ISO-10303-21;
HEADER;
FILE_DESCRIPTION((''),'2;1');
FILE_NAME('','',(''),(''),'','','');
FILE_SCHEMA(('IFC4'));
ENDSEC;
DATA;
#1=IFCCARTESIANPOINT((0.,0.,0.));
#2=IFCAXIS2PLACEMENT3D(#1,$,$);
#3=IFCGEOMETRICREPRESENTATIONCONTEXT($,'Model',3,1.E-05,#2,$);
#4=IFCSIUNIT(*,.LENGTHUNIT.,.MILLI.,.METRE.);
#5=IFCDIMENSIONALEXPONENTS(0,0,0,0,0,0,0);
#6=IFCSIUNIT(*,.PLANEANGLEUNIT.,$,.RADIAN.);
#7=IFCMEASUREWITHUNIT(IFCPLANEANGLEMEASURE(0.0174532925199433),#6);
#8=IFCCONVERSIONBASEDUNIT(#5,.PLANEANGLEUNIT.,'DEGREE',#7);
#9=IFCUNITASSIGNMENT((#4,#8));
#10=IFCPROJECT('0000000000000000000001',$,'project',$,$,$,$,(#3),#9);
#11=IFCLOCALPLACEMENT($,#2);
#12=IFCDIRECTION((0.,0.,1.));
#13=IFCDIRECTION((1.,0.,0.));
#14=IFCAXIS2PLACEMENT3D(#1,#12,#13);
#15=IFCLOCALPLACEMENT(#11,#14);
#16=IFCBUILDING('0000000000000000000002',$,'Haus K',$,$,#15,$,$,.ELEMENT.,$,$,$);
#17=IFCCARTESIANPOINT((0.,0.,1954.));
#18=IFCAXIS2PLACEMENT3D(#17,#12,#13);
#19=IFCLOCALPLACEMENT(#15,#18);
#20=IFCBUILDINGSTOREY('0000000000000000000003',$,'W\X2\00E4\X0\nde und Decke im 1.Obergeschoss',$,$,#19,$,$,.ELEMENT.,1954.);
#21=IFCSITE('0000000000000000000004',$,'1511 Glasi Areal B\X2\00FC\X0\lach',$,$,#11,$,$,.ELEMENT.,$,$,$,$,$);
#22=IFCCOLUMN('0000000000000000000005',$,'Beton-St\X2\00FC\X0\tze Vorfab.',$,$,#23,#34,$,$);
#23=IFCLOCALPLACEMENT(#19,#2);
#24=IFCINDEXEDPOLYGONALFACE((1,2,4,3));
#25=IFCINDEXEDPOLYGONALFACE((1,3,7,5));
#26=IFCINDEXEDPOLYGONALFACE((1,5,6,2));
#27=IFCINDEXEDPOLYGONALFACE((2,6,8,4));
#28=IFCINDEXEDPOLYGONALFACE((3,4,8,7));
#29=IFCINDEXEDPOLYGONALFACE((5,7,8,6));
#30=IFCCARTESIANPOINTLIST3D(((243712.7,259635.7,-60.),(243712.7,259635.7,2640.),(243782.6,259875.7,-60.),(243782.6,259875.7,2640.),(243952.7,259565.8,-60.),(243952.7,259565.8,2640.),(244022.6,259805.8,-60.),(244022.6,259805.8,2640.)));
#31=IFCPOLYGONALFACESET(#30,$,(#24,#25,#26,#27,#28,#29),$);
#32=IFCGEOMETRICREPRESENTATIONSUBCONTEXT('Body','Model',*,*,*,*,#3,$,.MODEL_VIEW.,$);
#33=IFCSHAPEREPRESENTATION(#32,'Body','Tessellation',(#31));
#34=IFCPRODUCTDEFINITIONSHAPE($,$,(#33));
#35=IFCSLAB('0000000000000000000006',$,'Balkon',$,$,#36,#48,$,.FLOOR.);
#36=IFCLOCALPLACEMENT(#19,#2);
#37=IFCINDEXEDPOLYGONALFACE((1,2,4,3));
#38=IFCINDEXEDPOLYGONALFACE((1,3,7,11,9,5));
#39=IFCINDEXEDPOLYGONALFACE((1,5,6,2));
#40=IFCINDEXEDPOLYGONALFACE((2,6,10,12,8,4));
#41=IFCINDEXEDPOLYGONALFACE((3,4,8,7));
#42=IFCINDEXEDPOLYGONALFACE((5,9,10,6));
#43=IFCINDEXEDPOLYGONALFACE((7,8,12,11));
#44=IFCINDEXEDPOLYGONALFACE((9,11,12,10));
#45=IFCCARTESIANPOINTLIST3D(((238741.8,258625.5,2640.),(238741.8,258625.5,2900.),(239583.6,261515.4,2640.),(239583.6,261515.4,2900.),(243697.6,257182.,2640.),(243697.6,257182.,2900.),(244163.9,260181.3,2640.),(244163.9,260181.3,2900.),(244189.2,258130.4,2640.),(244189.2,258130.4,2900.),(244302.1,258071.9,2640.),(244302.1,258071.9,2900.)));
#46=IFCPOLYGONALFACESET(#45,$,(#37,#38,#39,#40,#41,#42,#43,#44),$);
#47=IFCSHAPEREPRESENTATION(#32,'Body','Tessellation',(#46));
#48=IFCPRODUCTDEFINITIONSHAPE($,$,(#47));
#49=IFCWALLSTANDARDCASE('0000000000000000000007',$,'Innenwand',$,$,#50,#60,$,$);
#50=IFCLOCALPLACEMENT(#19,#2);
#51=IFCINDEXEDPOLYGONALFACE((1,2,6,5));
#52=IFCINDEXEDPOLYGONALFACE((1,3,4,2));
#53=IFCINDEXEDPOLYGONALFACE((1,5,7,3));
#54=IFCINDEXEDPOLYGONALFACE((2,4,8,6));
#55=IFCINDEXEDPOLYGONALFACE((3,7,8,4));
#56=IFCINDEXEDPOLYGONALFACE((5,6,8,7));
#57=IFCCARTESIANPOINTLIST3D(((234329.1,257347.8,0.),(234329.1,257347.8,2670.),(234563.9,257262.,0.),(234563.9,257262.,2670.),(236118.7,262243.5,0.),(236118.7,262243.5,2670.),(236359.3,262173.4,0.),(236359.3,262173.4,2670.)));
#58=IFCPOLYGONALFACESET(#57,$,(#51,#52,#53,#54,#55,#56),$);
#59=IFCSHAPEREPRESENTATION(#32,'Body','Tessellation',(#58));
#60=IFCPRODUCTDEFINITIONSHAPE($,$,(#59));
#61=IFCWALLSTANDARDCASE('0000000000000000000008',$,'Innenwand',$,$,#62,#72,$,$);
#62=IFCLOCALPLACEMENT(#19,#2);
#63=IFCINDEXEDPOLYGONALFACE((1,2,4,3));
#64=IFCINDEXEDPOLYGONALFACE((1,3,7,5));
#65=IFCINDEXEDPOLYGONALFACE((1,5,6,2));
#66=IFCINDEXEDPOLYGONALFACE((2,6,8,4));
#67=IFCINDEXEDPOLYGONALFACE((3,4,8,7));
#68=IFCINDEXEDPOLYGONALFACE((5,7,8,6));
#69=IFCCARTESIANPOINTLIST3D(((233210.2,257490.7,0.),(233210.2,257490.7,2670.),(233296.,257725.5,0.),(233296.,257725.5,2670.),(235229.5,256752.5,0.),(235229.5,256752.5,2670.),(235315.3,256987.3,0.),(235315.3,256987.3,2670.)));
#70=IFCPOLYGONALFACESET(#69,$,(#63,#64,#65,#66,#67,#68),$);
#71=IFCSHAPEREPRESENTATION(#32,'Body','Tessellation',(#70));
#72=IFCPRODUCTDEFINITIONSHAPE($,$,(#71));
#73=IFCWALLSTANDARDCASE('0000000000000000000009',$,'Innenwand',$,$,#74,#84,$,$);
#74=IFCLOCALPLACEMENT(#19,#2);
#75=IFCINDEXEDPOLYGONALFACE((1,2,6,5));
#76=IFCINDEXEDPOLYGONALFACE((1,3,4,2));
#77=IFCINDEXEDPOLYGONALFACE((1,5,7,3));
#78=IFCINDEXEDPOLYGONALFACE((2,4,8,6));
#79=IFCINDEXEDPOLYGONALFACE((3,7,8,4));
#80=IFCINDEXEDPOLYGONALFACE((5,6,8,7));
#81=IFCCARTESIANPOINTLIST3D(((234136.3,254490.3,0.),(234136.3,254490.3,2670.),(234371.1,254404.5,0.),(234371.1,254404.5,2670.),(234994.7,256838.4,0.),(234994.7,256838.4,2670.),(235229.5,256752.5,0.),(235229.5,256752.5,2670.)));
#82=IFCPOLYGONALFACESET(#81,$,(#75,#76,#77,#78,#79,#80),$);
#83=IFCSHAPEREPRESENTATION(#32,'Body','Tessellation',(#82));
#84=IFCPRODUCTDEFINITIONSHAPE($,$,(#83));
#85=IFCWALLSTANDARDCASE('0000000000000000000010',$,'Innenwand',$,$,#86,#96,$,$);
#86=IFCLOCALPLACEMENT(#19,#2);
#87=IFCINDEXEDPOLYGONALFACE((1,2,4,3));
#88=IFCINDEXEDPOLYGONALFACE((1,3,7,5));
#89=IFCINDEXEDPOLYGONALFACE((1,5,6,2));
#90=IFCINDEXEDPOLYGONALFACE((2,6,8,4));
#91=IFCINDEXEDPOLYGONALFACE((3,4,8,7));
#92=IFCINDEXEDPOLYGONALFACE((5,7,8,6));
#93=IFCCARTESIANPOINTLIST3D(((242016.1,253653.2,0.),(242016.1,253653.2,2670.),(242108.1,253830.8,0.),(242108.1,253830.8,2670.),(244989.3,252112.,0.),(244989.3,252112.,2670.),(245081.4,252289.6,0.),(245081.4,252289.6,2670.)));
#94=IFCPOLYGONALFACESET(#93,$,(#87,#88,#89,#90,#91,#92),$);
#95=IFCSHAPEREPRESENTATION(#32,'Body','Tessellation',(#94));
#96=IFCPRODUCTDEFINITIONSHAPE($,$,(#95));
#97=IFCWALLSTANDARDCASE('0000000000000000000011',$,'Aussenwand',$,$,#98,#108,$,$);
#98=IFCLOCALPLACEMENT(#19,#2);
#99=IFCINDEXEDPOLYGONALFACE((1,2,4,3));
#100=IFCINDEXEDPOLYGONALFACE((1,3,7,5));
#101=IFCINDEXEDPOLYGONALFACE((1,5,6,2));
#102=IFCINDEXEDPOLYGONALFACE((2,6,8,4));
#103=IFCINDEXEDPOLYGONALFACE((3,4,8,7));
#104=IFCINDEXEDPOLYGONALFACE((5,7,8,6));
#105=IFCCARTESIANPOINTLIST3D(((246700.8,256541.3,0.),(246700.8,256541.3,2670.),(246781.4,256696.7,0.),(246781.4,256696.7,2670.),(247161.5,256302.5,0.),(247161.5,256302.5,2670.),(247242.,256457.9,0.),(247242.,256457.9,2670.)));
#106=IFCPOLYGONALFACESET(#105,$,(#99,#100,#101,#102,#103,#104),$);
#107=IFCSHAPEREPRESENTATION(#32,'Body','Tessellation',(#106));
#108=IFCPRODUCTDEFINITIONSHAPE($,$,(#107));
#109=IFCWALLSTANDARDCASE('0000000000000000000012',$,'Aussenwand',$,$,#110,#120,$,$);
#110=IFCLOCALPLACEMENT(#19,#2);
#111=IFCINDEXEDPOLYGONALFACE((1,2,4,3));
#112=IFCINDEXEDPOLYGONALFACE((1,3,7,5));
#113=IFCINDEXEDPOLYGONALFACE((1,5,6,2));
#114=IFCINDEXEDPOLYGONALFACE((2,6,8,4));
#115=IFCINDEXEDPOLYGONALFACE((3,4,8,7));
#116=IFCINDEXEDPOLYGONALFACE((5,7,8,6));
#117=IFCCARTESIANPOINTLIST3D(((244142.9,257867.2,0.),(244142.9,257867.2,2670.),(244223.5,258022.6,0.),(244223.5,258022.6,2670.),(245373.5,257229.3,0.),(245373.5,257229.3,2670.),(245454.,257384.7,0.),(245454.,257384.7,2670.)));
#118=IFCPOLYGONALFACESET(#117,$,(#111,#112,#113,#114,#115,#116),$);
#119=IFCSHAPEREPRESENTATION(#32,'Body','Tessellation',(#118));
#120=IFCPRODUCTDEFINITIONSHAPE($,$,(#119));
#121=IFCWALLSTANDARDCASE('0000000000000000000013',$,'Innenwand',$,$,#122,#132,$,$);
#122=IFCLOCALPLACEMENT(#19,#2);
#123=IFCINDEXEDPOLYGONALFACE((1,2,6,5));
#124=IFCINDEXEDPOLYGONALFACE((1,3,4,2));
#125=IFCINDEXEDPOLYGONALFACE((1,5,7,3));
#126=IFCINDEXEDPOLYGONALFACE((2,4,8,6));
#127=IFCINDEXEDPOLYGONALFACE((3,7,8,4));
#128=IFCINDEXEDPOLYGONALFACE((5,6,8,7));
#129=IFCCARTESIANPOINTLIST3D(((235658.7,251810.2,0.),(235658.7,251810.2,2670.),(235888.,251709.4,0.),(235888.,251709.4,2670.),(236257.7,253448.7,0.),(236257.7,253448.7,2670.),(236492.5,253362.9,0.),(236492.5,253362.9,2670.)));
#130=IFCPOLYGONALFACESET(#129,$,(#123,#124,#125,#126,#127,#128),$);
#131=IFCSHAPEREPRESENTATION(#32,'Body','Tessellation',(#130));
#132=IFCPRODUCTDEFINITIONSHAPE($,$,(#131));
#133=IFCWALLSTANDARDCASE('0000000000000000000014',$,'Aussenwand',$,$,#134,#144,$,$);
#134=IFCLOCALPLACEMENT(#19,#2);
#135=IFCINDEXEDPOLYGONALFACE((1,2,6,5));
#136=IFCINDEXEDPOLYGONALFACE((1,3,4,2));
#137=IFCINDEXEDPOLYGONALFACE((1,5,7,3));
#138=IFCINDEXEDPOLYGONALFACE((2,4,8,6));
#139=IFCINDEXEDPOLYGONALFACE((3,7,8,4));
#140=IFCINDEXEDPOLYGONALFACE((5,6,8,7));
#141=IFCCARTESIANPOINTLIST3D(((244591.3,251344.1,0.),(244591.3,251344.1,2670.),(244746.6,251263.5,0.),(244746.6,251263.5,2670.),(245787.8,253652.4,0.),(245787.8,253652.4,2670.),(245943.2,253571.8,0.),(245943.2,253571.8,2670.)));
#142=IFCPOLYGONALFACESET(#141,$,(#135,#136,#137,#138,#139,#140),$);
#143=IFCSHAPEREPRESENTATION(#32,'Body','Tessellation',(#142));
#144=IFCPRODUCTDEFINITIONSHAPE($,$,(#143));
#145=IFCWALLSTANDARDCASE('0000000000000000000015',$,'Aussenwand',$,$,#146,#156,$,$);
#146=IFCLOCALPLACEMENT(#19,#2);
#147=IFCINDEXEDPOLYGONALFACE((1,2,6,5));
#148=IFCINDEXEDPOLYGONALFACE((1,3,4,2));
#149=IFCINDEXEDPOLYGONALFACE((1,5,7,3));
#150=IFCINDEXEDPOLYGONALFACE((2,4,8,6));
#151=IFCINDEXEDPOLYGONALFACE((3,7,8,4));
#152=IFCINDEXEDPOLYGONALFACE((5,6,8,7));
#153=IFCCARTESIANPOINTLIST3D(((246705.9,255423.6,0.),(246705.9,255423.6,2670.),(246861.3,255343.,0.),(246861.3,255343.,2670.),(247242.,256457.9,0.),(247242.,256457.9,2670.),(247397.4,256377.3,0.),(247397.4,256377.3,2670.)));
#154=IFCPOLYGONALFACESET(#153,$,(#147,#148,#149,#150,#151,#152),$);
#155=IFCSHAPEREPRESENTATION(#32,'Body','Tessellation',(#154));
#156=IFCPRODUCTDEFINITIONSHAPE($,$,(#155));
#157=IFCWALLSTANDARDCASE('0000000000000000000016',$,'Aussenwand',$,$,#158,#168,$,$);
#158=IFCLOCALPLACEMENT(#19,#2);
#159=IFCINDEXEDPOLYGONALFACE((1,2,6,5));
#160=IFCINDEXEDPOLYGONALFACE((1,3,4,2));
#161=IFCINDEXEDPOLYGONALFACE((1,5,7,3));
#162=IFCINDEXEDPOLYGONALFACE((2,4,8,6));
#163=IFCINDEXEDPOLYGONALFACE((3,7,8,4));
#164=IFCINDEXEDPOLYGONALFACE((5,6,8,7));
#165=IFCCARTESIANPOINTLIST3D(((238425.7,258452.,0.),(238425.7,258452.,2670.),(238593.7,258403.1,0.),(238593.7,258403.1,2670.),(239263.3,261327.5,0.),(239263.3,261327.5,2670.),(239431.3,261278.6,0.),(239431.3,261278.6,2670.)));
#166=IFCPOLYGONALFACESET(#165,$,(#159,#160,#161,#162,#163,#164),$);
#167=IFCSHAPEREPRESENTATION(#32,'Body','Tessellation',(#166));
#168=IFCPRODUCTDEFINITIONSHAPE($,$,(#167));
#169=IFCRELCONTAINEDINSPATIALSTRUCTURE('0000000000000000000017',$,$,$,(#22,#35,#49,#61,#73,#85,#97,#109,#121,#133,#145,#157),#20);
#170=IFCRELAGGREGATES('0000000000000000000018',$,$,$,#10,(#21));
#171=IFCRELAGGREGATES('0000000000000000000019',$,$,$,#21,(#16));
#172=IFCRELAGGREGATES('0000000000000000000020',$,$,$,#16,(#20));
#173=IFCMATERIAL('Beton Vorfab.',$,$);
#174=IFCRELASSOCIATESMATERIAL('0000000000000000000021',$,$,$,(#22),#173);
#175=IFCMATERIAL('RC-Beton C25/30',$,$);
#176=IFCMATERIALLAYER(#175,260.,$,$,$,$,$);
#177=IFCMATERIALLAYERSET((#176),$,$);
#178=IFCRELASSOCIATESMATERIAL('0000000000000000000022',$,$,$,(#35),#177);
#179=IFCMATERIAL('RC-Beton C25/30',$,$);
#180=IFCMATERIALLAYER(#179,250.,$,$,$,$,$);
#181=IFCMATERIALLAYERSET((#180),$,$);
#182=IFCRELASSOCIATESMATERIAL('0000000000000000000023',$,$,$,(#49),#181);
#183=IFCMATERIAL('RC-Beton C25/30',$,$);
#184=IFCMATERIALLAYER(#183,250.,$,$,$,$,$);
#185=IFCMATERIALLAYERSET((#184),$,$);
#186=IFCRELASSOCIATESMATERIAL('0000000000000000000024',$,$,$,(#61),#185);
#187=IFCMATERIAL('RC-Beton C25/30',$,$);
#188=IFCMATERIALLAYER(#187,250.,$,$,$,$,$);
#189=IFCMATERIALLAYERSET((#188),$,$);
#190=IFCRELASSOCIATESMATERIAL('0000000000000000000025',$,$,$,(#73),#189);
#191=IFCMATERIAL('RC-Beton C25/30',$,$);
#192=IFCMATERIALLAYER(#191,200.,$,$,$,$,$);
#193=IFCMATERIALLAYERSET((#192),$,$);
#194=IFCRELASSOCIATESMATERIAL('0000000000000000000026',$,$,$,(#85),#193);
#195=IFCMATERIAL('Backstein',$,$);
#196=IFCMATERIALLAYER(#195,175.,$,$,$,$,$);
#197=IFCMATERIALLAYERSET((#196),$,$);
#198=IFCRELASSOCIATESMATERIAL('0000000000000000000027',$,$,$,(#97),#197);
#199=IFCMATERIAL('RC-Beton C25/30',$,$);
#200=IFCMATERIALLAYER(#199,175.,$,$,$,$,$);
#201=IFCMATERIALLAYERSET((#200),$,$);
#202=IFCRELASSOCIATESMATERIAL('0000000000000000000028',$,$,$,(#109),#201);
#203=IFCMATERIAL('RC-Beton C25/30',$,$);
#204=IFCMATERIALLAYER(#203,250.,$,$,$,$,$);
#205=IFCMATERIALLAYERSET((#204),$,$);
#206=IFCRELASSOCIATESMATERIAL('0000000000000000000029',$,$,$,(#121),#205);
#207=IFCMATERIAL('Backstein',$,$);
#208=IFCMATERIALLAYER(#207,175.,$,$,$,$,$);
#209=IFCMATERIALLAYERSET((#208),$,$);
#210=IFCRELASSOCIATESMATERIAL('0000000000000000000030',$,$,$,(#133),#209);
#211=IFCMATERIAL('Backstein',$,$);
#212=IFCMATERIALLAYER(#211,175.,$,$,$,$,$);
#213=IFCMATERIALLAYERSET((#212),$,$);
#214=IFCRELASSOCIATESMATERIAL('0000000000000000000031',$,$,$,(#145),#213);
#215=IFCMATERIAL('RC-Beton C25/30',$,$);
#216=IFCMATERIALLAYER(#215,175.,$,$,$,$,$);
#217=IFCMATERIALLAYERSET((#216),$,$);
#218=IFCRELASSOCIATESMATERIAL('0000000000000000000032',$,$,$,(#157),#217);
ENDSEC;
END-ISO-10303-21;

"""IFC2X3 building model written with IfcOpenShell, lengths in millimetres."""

from ifc_helpers import new_model, entity, si_unit, converted_unit, frame, frame_2d, origin, origin_with_axes, place, context, subcontext, project, spatial, polyline, rectangle, outline, extrude, material, layer, layer_set, layer_usage, element, save


model = new_model("IFC2X3")

# Units and contexts
model_context = context("Model", 3, precision=1e-05, world=origin())
body_context = subcontext(model_context, "Body", "Model", "MODEL_VIEW")
ifc_project = project(units=[si_unit("LENGTHUNIT", "METRE", prefix="MILLI"), converted_unit("PLANEANGLEUNIT", "DEGREE", entity("IfcPlaneAngleMeasure", 0.0174532925199433), si_unit("PLANEANGLEUNIT", "RADIAN"), dimensions=[0, 0, 0, 0, 0, 0, 0])], contexts=[model_context])

# Site, building, storey
site_placement = place(None, origin())
site = spatial("IfcSite", under=ifc_project, at=site_placement, Name="1511 Glasi Areal Bülach", CompositionType="ELEMENT")
building_placement = place(site_placement, origin_with_axes())
building = spatial("IfcBuilding", under=site, at=building_placement, Name="Haus K", CompositionType="ELEMENT")
storey_placement = place(building_placement, frame((0.0, 0.0, 1954.0), z_axis=(0.0, 0.0, 1.0), x_axis=(1.0, 0.0, 0.0)))
storey = spatial("IfcBuildingStorey", under=building, at=storey_placement, Name="Wände und Decke im 1.Obergeschoss", CompositionType="ELEMENT", Elevation=1954.0)

# Column
ifc_material_1 = material(Name="Beton Vorfab.")
column_placement = place(storey_placement, frame((243712.7, 259635.7, -60.0), z_axis=(0.0, 0.0, 1.0), x_axis=(1.0, 0.0, 0.0)))
element("IfcColumn", 1, at=column_placement, inside=storey, material=ifc_material_1, Name="Beton-Stütze Vorfab.", context=body_context, shape_type="SweptSolid", body=[
    extrude(rectangle(XDim=250.0, YDim=250.0, at=frame_2d((155.0, 85.1), x_axis=(0.960099, -0.279661))), origin_with_axes(), (0.0, 0.0, 1.0), 2700.0),
])

# Slab
ifc_material_2 = material(Name="RC-Beton C25/30")
ifc_layer_1 = layer(ifc_material_2, 260.0)
ifc_layer_set_1 = layer_set([ifc_layer_1])
ifc_layer_usage_1 = layer_usage(ifc_layer_set_1, "AXIS3", "POSITIVE", 0.0)
slab_placement = place(storey_placement, frame((238741.8, 257182.0, 2640.0), z_axis=(0.0, 0.0, 1.0), x_axis=(1.0, 0.0, 0.0)))
element("IfcSlab", 2, at=slab_placement, inside=storey, material=ifc_layer_usage_1, Name="Balkon", PredefinedType="FLOOR", context=body_context, shape_type="SweptSolid", body=[
    extrude(outline(polyline([(841.8, 4333.4), (0.0, 1443.5), (4955.8, 0.0), (5447.4, 948.4), (5560.3, 889.9), (5422.0, 2999.3), (841.8, 4333.4)])), origin_with_axes(), (0.0, 0.0, 1.0), 260.0),
])

# Walls
ifc_material_3 = material(Name="RC-Beton C25/30")
ifc_layer_2 = layer(ifc_material_3, 250.0)
ifc_layer_set_2 = layer_set([ifc_layer_2])
ifc_layer_usage_2 = layer_usage(ifc_layer_set_2, "AXIS2", "POSITIVE", 0.0)
wall_1_placement = place(storey_placement, frame((234563.9, 257262.0, 0.0), z_axis=(0.0, 0.0, 1.0), x_axis=(0.343332, 0.939214, 0.0)))
element("IfcWallStandardCase", 3, at=wall_1_placement, inside=storey, material=ifc_layer_usage_2, Name="Innenwand", context=body_context, shape_type="SweptSolid", body=[
    extrude(outline(polyline([(0.0, 0.0), (5229.2, 0.0), (5212.5, 250.0), (0.0, 250.0), (0.0, 0.0)])), origin_with_axes(), (0.0, 0.0, 1.0), 2670.0),
])
ifc_material_4 = material(Name="RC-Beton C25/30")
ifc_layer_3 = layer(ifc_material_4, 250.0)
ifc_layer_set_3 = layer_set([ifc_layer_3])
ifc_layer_usage_3 = layer_usage(ifc_layer_set_3, "AXIS2", "POSITIVE", 0.0)
wall_2_placement = place(storey_placement, frame((235315.3, 256987.3, 0.0), z_axis=(0.0, 0.0, 1.0), x_axis=(-0.939214, 0.343332, 0.0)))
element("IfcWallStandardCase", 4, at=wall_2_placement, inside=storey, material=ifc_layer_usage_3, Name="Innenwand", context=body_context, shape_type="SweptSolid", body=[
    extrude(rectangle(XDim=2150.0, YDim=250.0, at=frame_2d((1075.0, 125.0), x_axis=(1.0, 0.0))), origin_with_axes(), (0.0, 0.0, 1.0), 2670.0),
])
ifc_material_5 = material(Name="RC-Beton C25/30")
ifc_layer_4 = layer(ifc_material_5, 250.0)
ifc_layer_set_4 = layer_set([ifc_layer_4])
ifc_layer_usage_4 = layer_usage(ifc_layer_set_4, "AXIS2", "POSITIVE", 0.0)
wall_3_placement = place(storey_placement, frame((234371.1, 254404.5, 0.0), z_axis=(0.0, 0.0, 1.0), x_axis=(0.343332, 0.939214, 0.0)))
element("IfcWallStandardCase", 5, at=wall_3_placement, inside=storey, material=ifc_layer_usage_4, Name="Innenwand", context=body_context, shape_type="SweptSolid", body=[
    extrude(rectangle(XDim=2500.0, YDim=250.0, at=frame_2d((1250.0, 125.0), x_axis=(1.0, 0.0))), origin_with_axes(), (0.0, 0.0, 1.0), 2670.0),
])
ifc_material_6 = material(Name="RC-Beton C25/30")
ifc_layer_5 = layer(ifc_material_6, 200.0)
ifc_layer_set_5 = layer_set([ifc_layer_5])
ifc_layer_usage_5 = layer_usage(ifc_layer_set_5, "AXIS2", "POSITIVE", 0.0)
wall_4_placement = place(storey_placement, frame((245081.4, 252289.6, 0.0), z_axis=(0.0, 0.0, 1.0), x_axis=(-0.887815, 0.4602, 0.0)))
element("IfcWallStandardCase", 6, at=wall_4_placement, inside=storey, material=ifc_layer_usage_5, Name="Innenwand", context=body_context, shape_type="SweptSolid", body=[
    extrude(rectangle(XDim=3349.0, YDim=200.0, at=frame_2d((1674.5, 100.0), x_axis=(1.0, 0.0))), origin_with_axes(), (0.0, 0.0, 1.0), 2670.0),
])
ifc_material_7 = material(Name="Backstein")
ifc_layer_6 = layer(ifc_material_7, 175.0)
ifc_layer_set_6 = layer_set([ifc_layer_6])
ifc_layer_usage_6 = layer_usage(ifc_layer_set_6, "AXIS2", "POSITIVE", 0.0)
wall_5_placement = place(storey_placement, frame((247242.0, 256457.9, 0.0), z_axis=(0.0, 0.0, 1.0), x_axis=(-0.887815, 0.4602, 0.0)))
element("IfcWallStandardCase", 7, at=wall_5_placement, inside=storey, material=ifc_layer_usage_6, Name="Aussenwand", context=body_context, shape_type="SweptSolid", body=[
    extrude(outline(polyline([(0.0, 0.0), (518.9, 0.0), (518.9, 175.0), (0.0, 175.0), (0.0, 0.0)])), origin_with_axes(), (0.0, 0.0, 1.0), 2670.0),
])
ifc_material_8 = material(Name="RC-Beton C25/30")
ifc_layer_7 = layer(ifc_material_8, 175.0)
ifc_layer_set_7 = layer_set([ifc_layer_7])
ifc_layer_usage_7 = layer_usage(ifc_layer_set_7, "AXIS2", "POSITIVE", 0.0)
wall_6_placement = place(storey_placement, frame((245454.0, 257384.7, 0.0), z_axis=(0.0, 0.0, 1.0), x_axis=(-0.887815, 0.4602, 0.0)))
element("IfcWallStandardCase", 8, at=wall_6_placement, inside=storey, material=ifc_layer_usage_7, Name="Aussenwand", context=body_context, shape_type="SweptSolid", body=[
    extrude(rectangle(XDim=1386.1, YDim=175.0, at=frame_2d((693.0, 87.5), x_axis=(1.0, 0.0))), origin_with_axes(), (0.0, 0.0, 1.0), 2670.0),
])
ifc_material_9 = material(Name="RC-Beton C25/30")
ifc_layer_8 = layer(ifc_material_9, 250.0)
ifc_layer_set_8 = layer_set([ifc_layer_8])
ifc_layer_usage_8 = layer_usage(ifc_layer_set_8, "AXIS2", "POSITIVE", 0.0)
wall_7_placement = place(storey_placement, frame((236257.7, 253448.7, 0.0), z_axis=(0.0, 0.0, 1.0), x_axis=(-0.343332, -0.939214, 0.0)))
element("IfcWallStandardCase", 9, at=wall_7_placement, inside=storey, material=ifc_layer_usage_8, Name="Innenwand", context=body_context, shape_type="SweptSolid", body=[
    extrude(outline(polyline([(0.0, 0.0), (1744.5, 0.0), (1760.5, 250.0), (0.0, 250.0), (0.0, 0.0)])), origin_with_axes(), (0.0, 0.0, 1.0), 2670.0),
])
ifc_material_10 = material(Name="Backstein")
ifc_layer_9 = layer(ifc_material_10, 175.0)
ifc_layer_set_9 = layer_set([ifc_layer_9])
ifc_layer_usage_9 = layer_usage(ifc_layer_set_9, "AXIS2", "POSITIVE", 0.0)
wall_8_placement = place(storey_placement, frame((244746.6, 251263.5, 0.0), z_axis=(0.0, 0.0, 1.0), x_axis=(0.4602, 0.887815, 0.0)))
element("IfcWallStandardCase", 10, at=wall_8_placement, inside=storey, material=ifc_layer_usage_9, Name="Aussenwand", context=body_context, shape_type="SweptSolid", body=[
    extrude(rectangle(XDim=2600.0, YDim=175.0, at=frame_2d((1300.0, 87.5), x_axis=(1.0, 0.0))), origin_with_axes(), (0.0, 0.0, 1.0), 2670.0),
])
ifc_material_11 = material(Name="Backstein")
ifc_layer_10 = layer(ifc_material_11, 175.0)
ifc_layer_set_10 = layer_set([ifc_layer_10])
ifc_layer_usage_10 = layer_usage(ifc_layer_set_10, "AXIS2", "POSITIVE", 0.0)
wall_9_placement = place(storey_placement, frame((246861.3, 255343.0, 0.0), z_axis=(0.0, 0.0, 1.0), x_axis=(0.4602, 0.887815, 0.0)))
element("IfcWallStandardCase", 11, at=wall_9_placement, inside=storey, material=ifc_layer_usage_10, Name="Aussenwand", context=body_context, shape_type="SweptSolid", body=[
    extrude(rectangle(XDim=1165.0, YDim=175.0, at=frame_2d((582.5, 87.5), x_axis=(1.0, 0.0))), origin_with_axes(), (0.0, 0.0, 1.0), 2670.0),
])
ifc_material_12 = material(Name="RC-Beton C25/30")
ifc_layer_11 = layer(ifc_material_12, 175.0)
ifc_layer_set_11 = layer_set([ifc_layer_11])
ifc_layer_usage_11 = layer_usage(ifc_layer_set_11, "AXIS2", "POSITIVE", 0.0)
wall_10_placement = place(storey_placement, frame((238593.7, 258403.1, 0.0), z_axis=(0.0, 0.0, 1.0), x_axis=(0.279661, 0.960099, 0.0)))
element("IfcWallStandardCase", 12, at=wall_10_placement, inside=storey, material=ifc_layer_usage_11, Name="Aussenwand", context=body_context, shape_type="SweptSolid", body=[
    extrude(rectangle(XDim=2995.0, YDim=175.0, at=frame_2d((1497.5, 87.5), x_axis=(1.0, 0.0))), origin_with_axes(), (0.0, 0.0, 1.0), 2670.0),
])

save(model, "model.ifc")
